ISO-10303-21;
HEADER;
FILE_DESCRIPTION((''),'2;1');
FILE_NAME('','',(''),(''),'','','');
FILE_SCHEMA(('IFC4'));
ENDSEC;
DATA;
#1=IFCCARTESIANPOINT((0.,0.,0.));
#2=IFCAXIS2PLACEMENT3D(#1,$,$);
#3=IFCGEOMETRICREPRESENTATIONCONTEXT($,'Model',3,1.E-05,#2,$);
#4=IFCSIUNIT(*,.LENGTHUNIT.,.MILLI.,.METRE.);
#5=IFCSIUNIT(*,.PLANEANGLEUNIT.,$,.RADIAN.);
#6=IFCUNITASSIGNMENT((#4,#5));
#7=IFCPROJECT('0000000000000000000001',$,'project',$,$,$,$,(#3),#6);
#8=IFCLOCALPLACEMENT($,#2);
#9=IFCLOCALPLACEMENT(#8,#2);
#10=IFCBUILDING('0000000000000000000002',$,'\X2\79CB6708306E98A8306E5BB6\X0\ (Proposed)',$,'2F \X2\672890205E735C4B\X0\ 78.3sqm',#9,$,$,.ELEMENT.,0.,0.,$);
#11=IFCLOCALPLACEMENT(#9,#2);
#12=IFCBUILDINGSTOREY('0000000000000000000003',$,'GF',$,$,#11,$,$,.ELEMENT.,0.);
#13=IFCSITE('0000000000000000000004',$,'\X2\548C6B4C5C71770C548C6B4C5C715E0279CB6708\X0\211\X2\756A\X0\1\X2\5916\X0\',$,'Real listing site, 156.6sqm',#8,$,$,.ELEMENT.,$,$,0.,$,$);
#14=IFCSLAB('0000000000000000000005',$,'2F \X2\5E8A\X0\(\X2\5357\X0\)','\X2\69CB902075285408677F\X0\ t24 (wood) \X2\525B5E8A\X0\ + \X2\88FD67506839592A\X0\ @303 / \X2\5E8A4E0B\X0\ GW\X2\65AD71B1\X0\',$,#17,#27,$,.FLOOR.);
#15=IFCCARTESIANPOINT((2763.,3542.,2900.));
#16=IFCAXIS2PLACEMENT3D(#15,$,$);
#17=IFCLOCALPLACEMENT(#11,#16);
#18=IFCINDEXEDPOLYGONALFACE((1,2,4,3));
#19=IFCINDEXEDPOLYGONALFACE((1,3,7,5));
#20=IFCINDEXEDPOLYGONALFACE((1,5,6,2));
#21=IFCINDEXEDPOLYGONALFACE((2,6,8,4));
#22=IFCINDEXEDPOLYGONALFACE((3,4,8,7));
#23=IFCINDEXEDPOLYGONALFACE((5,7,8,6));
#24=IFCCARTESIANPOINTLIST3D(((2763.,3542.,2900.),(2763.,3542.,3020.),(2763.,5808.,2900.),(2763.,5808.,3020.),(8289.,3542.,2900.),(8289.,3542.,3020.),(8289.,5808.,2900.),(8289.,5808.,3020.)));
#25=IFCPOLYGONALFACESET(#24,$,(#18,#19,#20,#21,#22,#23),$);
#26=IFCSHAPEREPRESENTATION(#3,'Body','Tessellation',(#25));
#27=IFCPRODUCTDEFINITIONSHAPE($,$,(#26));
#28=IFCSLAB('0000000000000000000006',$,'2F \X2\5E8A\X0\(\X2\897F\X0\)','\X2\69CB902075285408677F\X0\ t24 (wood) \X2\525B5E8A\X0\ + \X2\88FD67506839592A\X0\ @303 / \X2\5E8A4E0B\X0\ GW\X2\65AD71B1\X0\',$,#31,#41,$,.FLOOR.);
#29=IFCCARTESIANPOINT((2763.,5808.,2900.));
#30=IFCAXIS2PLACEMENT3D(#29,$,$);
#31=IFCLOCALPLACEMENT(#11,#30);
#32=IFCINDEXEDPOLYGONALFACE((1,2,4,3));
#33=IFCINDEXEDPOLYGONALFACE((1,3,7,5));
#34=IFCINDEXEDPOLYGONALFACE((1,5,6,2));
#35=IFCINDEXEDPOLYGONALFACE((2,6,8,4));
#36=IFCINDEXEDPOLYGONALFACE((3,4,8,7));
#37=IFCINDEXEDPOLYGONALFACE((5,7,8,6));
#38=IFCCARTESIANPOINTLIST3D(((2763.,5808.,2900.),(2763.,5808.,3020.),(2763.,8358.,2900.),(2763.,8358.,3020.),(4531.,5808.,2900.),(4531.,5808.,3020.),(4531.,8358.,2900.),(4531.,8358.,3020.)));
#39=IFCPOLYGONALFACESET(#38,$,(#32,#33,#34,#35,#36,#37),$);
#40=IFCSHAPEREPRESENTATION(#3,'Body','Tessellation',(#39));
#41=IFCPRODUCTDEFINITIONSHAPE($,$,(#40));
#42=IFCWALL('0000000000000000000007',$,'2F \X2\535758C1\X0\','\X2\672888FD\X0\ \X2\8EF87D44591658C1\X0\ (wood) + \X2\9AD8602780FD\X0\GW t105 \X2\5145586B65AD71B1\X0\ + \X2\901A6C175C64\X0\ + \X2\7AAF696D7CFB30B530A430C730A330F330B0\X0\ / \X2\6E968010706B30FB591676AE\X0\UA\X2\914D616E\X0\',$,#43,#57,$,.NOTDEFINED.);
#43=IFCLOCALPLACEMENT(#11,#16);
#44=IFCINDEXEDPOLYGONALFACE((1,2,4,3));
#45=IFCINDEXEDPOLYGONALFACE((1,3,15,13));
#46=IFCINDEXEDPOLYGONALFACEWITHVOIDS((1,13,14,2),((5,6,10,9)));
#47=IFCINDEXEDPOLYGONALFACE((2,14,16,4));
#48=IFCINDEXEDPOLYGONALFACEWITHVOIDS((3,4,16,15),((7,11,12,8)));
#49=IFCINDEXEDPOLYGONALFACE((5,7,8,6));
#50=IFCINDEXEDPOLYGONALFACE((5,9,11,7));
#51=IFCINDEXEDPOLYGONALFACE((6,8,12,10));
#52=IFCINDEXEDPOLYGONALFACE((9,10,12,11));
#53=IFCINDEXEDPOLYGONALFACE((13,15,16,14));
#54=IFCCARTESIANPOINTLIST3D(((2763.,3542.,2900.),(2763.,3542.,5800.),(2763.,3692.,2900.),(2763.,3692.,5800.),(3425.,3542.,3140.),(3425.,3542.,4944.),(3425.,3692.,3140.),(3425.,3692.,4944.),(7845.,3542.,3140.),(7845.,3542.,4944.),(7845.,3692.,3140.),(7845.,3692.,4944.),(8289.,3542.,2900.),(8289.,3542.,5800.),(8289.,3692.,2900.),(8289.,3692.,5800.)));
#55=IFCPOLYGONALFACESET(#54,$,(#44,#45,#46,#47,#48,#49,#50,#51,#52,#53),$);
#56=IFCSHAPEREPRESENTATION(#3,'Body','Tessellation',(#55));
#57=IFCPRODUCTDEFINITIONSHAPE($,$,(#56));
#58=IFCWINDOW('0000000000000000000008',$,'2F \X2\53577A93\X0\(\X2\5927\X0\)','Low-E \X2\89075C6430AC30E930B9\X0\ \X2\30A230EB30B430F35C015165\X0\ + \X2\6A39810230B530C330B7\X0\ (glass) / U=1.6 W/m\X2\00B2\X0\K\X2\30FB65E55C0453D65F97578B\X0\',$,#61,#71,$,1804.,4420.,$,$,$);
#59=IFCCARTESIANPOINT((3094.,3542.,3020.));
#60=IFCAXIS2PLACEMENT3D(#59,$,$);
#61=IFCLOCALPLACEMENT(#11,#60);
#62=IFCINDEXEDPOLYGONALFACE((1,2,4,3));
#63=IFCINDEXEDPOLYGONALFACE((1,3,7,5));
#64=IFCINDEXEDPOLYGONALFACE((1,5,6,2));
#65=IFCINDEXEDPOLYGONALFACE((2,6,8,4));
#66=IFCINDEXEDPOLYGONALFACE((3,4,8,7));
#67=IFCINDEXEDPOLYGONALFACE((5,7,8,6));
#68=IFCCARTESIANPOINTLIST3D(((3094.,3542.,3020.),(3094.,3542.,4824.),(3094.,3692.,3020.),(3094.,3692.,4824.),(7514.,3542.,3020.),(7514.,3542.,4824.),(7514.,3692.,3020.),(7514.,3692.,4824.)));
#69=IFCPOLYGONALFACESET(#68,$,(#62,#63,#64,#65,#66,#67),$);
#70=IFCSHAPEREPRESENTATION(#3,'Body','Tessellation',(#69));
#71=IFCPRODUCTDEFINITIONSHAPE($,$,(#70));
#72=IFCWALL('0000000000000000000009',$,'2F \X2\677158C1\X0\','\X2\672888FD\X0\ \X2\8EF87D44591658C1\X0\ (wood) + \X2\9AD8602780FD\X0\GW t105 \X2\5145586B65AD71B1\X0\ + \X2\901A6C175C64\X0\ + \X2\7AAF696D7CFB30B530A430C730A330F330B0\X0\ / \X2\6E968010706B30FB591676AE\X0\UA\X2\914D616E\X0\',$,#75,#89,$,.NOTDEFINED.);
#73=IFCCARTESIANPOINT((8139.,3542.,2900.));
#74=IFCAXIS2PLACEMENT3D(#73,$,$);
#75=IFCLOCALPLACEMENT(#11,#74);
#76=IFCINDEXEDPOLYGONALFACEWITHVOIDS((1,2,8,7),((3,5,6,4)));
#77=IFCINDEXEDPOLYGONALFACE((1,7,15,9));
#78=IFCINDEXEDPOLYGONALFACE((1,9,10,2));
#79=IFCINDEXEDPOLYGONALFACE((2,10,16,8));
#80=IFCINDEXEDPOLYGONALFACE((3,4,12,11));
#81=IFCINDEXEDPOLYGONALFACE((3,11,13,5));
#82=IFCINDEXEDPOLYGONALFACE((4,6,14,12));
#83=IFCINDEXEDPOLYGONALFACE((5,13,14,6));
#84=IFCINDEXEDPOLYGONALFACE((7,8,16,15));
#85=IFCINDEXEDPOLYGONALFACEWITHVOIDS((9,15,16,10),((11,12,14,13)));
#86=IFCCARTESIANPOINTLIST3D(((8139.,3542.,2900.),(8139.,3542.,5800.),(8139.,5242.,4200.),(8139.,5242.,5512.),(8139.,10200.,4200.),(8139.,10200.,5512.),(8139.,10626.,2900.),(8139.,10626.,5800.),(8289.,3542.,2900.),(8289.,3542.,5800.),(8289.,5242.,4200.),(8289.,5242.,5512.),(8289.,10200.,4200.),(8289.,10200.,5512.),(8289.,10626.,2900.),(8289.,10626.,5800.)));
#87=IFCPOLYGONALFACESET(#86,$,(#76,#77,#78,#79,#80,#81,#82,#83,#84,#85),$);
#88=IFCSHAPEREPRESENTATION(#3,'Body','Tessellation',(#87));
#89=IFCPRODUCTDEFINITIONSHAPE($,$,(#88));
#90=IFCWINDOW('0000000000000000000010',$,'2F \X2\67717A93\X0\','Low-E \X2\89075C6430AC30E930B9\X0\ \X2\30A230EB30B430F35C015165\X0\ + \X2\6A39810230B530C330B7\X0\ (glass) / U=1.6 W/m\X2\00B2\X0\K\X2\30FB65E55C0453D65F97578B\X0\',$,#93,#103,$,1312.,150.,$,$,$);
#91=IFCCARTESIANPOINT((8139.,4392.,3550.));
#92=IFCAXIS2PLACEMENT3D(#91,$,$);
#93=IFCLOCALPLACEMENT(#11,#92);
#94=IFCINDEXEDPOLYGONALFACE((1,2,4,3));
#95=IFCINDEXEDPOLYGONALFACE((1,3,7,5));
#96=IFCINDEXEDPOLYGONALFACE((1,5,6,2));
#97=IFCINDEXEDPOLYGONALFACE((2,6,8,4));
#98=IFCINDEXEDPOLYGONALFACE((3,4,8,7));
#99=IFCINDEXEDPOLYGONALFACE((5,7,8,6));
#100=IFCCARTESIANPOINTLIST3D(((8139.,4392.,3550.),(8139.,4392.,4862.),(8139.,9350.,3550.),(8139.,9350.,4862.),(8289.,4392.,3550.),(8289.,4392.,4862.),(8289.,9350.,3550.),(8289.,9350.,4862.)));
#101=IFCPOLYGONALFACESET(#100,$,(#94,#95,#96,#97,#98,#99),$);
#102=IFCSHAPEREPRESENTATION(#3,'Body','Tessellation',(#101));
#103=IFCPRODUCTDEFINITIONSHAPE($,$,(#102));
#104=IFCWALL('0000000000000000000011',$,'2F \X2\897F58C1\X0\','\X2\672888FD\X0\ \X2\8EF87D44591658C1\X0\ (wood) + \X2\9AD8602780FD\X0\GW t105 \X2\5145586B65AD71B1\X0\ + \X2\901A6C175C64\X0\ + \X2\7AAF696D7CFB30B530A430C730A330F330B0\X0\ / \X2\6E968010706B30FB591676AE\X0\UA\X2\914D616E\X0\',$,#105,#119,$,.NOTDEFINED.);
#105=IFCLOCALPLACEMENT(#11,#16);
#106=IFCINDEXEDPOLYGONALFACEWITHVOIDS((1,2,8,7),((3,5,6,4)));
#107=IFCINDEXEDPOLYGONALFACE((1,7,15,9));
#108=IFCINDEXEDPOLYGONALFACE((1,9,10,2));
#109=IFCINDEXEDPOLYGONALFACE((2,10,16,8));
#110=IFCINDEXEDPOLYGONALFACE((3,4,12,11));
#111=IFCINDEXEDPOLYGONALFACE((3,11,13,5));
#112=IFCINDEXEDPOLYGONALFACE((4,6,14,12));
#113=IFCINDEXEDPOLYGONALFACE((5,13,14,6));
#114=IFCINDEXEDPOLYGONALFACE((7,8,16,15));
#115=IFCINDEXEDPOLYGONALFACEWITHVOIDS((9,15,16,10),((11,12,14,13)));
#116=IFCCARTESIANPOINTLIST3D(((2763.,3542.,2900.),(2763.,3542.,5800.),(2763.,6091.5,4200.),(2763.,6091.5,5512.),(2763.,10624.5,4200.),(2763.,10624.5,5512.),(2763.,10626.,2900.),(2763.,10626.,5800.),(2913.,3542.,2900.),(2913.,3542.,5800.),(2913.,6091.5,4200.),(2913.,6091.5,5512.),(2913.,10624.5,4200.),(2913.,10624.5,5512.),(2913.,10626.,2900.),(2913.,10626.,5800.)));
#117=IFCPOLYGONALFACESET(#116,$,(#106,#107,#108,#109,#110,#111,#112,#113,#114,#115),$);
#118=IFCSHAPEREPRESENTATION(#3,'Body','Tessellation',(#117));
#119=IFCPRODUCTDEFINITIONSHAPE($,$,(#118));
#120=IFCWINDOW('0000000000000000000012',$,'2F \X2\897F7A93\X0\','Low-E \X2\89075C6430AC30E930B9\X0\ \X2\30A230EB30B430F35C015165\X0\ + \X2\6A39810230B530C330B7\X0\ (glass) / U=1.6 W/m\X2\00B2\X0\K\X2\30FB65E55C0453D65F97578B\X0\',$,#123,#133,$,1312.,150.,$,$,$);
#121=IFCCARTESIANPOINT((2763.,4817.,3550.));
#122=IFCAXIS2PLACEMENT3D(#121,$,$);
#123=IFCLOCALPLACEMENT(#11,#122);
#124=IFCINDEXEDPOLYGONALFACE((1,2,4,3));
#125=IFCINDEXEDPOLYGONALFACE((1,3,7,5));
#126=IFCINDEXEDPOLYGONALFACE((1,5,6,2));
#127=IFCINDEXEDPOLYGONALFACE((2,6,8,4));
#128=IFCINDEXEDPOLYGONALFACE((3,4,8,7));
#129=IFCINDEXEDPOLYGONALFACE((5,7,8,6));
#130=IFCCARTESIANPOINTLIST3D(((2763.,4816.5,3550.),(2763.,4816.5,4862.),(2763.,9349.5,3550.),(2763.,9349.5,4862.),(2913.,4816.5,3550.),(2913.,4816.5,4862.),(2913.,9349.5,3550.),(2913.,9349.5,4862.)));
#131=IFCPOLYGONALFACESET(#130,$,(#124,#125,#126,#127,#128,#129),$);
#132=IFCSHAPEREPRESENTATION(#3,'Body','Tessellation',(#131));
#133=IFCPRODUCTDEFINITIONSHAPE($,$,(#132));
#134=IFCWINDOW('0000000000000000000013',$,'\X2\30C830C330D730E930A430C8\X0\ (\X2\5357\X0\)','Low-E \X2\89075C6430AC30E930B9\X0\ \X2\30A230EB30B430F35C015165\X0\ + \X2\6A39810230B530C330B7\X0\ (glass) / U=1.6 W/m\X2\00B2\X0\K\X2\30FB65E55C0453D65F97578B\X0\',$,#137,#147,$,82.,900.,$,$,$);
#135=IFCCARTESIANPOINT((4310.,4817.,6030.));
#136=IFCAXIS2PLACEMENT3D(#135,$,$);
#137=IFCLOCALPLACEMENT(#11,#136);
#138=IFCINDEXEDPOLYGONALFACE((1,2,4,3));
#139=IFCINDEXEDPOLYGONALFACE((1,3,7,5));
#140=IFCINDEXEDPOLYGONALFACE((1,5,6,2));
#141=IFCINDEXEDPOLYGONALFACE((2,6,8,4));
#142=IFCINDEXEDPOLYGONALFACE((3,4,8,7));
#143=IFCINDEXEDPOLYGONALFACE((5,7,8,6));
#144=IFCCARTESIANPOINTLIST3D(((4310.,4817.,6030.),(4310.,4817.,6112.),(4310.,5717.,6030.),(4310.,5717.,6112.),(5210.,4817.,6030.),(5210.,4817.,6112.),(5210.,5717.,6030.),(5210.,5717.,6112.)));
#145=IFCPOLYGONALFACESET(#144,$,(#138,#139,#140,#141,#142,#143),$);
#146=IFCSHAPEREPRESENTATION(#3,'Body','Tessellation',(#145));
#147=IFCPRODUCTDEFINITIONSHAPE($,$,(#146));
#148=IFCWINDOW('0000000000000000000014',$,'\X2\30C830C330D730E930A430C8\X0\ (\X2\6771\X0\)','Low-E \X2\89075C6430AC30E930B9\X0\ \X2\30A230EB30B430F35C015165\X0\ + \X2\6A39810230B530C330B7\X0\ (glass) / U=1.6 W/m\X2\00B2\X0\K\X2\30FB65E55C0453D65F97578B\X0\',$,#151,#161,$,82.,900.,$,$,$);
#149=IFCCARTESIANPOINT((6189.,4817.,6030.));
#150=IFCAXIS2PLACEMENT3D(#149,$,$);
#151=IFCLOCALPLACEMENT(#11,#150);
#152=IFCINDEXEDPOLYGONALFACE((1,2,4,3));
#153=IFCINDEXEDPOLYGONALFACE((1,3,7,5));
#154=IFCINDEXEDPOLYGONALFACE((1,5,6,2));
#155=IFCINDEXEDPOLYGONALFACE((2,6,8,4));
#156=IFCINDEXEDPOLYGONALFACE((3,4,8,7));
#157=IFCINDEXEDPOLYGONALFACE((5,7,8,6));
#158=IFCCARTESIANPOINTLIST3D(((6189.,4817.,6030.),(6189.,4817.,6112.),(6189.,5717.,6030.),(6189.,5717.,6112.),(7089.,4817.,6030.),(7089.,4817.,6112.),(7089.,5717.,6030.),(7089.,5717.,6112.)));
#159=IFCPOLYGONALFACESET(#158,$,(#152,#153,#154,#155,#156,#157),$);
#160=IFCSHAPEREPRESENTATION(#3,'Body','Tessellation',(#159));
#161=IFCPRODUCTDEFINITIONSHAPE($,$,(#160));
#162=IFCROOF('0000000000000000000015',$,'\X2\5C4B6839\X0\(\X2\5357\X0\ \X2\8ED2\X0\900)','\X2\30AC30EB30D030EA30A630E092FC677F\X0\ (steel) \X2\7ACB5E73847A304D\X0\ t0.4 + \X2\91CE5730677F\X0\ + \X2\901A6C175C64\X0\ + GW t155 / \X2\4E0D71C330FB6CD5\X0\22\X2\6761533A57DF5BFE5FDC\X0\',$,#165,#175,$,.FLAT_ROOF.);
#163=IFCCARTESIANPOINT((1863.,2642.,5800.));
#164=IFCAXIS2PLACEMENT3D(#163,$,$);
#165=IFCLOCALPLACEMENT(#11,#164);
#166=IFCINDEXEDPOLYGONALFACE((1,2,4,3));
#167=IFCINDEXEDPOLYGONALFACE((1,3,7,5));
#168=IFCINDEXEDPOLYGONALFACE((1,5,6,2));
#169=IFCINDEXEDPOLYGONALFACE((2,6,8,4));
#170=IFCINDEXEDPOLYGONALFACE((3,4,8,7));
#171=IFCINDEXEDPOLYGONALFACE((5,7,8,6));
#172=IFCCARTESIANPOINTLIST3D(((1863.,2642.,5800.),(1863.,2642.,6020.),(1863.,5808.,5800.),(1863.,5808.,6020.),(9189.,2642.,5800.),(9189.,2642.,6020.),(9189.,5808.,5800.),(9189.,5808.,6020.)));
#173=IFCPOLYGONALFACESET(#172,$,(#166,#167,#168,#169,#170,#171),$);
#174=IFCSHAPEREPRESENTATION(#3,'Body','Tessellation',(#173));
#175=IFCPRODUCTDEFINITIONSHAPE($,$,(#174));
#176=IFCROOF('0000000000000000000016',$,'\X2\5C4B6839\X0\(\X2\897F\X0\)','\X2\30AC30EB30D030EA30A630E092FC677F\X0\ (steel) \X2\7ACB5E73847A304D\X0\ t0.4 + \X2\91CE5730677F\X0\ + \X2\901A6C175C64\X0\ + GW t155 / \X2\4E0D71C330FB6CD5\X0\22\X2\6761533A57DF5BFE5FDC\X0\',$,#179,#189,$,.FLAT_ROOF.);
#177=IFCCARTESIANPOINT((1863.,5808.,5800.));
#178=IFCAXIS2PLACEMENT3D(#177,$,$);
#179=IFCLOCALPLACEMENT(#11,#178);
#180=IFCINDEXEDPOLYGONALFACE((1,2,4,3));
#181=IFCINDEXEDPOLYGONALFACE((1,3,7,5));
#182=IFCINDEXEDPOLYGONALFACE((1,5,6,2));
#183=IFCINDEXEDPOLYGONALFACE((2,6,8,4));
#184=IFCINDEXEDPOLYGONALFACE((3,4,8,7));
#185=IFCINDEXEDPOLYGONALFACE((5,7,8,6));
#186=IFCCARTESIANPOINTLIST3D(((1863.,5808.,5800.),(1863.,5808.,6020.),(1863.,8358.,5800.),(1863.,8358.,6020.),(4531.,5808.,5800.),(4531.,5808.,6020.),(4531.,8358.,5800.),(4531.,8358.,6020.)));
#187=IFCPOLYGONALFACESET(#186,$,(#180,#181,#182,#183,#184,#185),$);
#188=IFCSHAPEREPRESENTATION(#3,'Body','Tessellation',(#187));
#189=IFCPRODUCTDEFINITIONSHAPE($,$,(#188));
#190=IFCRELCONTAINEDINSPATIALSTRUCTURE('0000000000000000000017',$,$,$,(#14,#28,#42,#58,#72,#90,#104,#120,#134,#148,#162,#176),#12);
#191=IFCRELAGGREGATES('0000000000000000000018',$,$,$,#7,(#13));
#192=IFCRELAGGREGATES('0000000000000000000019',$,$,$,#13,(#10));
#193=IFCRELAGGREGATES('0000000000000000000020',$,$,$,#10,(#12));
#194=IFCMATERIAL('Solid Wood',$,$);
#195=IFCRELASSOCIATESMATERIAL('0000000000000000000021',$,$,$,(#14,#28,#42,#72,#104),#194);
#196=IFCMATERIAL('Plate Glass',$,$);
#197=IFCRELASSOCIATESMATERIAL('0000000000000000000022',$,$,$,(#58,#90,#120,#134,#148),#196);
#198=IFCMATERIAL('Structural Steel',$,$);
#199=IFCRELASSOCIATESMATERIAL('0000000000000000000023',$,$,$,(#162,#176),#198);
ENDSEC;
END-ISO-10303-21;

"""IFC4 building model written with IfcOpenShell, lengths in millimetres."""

from ifc_helpers import new_model, si_unit, frame, frame_2d, origin, place, context, project, spatial, rectangle, extrude, material, element, fill, save


model = new_model("IFC4")

# Units and contexts
model_context = context("Model", 3, precision=1e-05, world=origin())
ifc_project = project(units=[si_unit("LENGTHUNIT", "METRE", prefix="MILLI"), si_unit("PLANEANGLEUNIT", "RADIAN")], contexts=[model_context])

# Site, building, storey
site_placement = place(None, origin())
site = spatial("IfcSite", under=ifc_project, at=site_placement, Name="和歌山県和歌山市秋月211番1外", ObjectType="Real listing site, 156.6sqm", CompositionType="ELEMENT", RefElevation=0.0)
building_placement = place(site_placement, origin())
building = spatial("IfcBuilding", under=site, at=building_placement, Name="秋月の風の家 (Proposed)", ObjectType="2F 木造平屋 78.3sqm", CompositionType="ELEMENT", ElevationOfRefHeight=0.0, ElevationOfTerrain=0.0)
storey_placement = place(building_placement, origin())
storey = spatial("IfcBuildingStorey", under=building, at=storey_placement, Name="GF", CompositionType="ELEMENT", Elevation=0.0)

# Slabs
ifc_material_1 = material(Name="Solid Wood")
slab_1_placement = place(storey_placement, frame((2763.0, 3542.0, 2900.0)))
element("IfcSlab", 1, at=slab_1_placement, inside=storey, material=ifc_material_1, Name="2F 床(南)", Description="構造用合板 t24 (wood) 剛床 + 製材根太 @303 / 床下 GW断熱", PredefinedType="FLOOR", context=model_context, shape_type="SweptSolid", body=[
    extrude(rectangle(XDim=5526.0, YDim=2266.0, at=frame_2d((2763.0, 1133.0))), frame((2763.0, 3542.0, 2900.0)), (0.0, 0.0, 1.0), 120.0),
])
slab_2_placement = place(storey_placement, frame((2763.0, 5808.0, 2900.0)))
element("IfcSlab", 2, at=slab_2_placement, inside=storey, material=ifc_material_1, Name="2F 床(西)", Description="構造用合板 t24 (wood) 剛床 + 製材根太 @303 / 床下 GW断熱", PredefinedType="FLOOR", context=model_context, shape_type="SweptSolid", body=[
    extrude(rectangle(XDim=1768.0, YDim=2550.0, at=frame_2d((884.0, 1275.0))), frame((2763.0, 5808.0, 2900.0)), (0.0, 0.0, 1.0), 120.0),
])

# Walls, openings, windows
wall_1_placement = place(storey_placement, frame((2763.0, 3542.0, 2900.0)))
wall_1 = element("IfcWall", 3, at=wall_1_placement, inside=storey, material=ifc_material_1, Name="2F 南壁", Description="木製 軸組外壁 (wood) + 高性能GW t105 充填断熱 + 通気層 + 窯業系サイディング / 準耐火・外皮UA配慮", PredefinedType="NOTDEFINED", context=model_context, shape_type="SweptSolid", body=[
    extrude(rectangle(XDim=5526.0, YDim=150.0, at=frame_2d((2763.0, 75.0))), frame((2763.0, 3542.0, 2900.0)), (0.0, 0.0, 1.0), 2900.0),
])
opening_1_placement = place(storey_placement, frame((3094.0, 3542.0, 3020.0)))
opening_1 = element("IfcOpeningElement", 4, at=opening_1_placement, cuts=wall_1, PredefinedType="NOTDEFINED", context=model_context, shape_type="SweptSolid", body=[
    extrude(rectangle(XDim=4420.0, YDim=150.0, at=frame_2d((2210.0, 75.0))), frame((3094.0, 3542.0, 3020.0)), (0.0, 0.0, 1.0), 1804.0),
])
ifc_material_2 = material(Name="Plate Glass")
window_1_placement = place(storey_placement, frame((3094.0, 3542.0, 3020.0)))
window_1 = element("IfcWindow", 5, at=window_1_placement, inside=storey, material=ifc_material_2, Name="2F 南窓(大)", Description="Low-E 複層ガラス アルゴン封入 + 樹脂サッシ (glass) / U=1.6 W/m²K・日射取得型", OverallHeight=1804.0, OverallWidth=4420.0, context=model_context, shape_type="SweptSolid", body=[
    extrude(rectangle(XDim=4420.0, YDim=150.0, at=frame_2d((2210.0, 75.0))), frame((3094.0, 3542.0, 3020.0)), (0.0, 0.0, 1.0), 1804.0),
])
fill(opening_1, window_1)
wall_2_placement = place(storey_placement, frame((8139.0, 3542.0, 2900.0)))
wall_2 = element("IfcWall", 6, at=wall_2_placement, inside=storey, material=ifc_material_1, Name="2F 東壁", Description="木製 軸組外壁 (wood) + 高性能GW t105 充填断熱 + 通気層 + 窯業系サイディング / 準耐火・外皮UA配慮", PredefinedType="NOTDEFINED", context=model_context, shape_type="SweptSolid", body=[
    extrude(rectangle(XDim=150.0, YDim=7084.0, at=frame_2d((75.0, 3542.0))), frame((8139.0, 3542.0, 2900.0)), (0.0, 0.0, 1.0), 2900.0),
])
opening_2_placement = place(storey_placement, frame((8139.0, 4392.0, 3550.0)))
opening_2 = element("IfcOpeningElement", 7, at=opening_2_placement, cuts=wall_2, PredefinedType="NOTDEFINED", context=model_context, shape_type="SweptSolid", body=[
    extrude(rectangle(XDim=150.0, YDim=4958.0, at=frame_2d((75.0, 2479.0))), frame((8139.0, 4392.0, 3550.0)), (0.0, 0.0, 1.0), 1312.0),
])
window_2_placement = place(storey_placement, frame((8139.0, 4392.0, 3550.0)))
window_2 = element("IfcWindow", 8, at=window_2_placement, inside=storey, material=ifc_material_2, Name="2F 東窓", Description="Low-E 複層ガラス アルゴン封入 + 樹脂サッシ (glass) / U=1.6 W/m²K・日射取得型", OverallHeight=1312.0, OverallWidth=150.0, context=model_context, shape_type="SweptSolid", body=[
    extrude(rectangle(XDim=150.0, YDim=4958.0, at=frame_2d((75.0, 2479.0))), frame((8139.0, 4392.0, 3550.0)), (0.0, 0.0, 1.0), 1312.0),
])
fill(opening_2, window_2)
wall_3_placement = place(storey_placement, frame((2763.0, 3542.0, 2900.0)))
wall_3 = element("IfcWall", 9, at=wall_3_placement, inside=storey, material=ifc_material_1, Name="2F 西壁", Description="木製 軸組外壁 (wood) + 高性能GW t105 充填断熱 + 通気層 + 窯業系サイディング / 準耐火・外皮UA配慮", PredefinedType="NOTDEFINED", context=model_context, shape_type="SweptSolid", body=[
    extrude(rectangle(XDim=150.0, YDim=7084.0, at=frame_2d((75.0, 3542.0))), frame((2763.0, 3542.0, 2900.0)), (0.0, 0.0, 1.0), 2900.0),
])
opening_3_placement = place(storey_placement, frame((2763.0, 4817.0, 3550.0)))
opening_3 = element("IfcOpeningElement", 10, at=opening_3_placement, cuts=wall_3, PredefinedType="NOTDEFINED", context=model_context, shape_type="SweptSolid", body=[
    extrude(rectangle(XDim=150.0, YDim=4533.0, at=frame_2d((75.0, 2266.0))), frame((2763.0, 4817.0, 3550.0)), (0.0, 0.0, 1.0), 1312.0),
])
window_3_placement = place(storey_placement, frame((2763.0, 4817.0, 3550.0)))
window_3 = element("IfcWindow", 11, at=window_3_placement, inside=storey, material=ifc_material_2, Name="2F 西窓", Description="Low-E 複層ガラス アルゴン封入 + 樹脂サッシ (glass) / U=1.6 W/m²K・日射取得型", OverallHeight=1312.0, OverallWidth=150.0, context=model_context, shape_type="SweptSolid", body=[
    extrude(rectangle(XDim=150.0, YDim=4533.0, at=frame_2d((75.0, 2266.0))), frame((2763.0, 4817.0, 3550.0)), (0.0, 0.0, 1.0), 1312.0),
])
fill(opening_3, window_3)

# Windows
window_4_placement = place(storey_placement, frame((4310.0, 4817.0, 6030.0)))
element("IfcWindow", 12, at=window_4_placement, inside=storey, material=ifc_material_2, Name="トップライト (南)", Description="Low-E 複層ガラス アルゴン封入 + 樹脂サッシ (glass) / U=1.6 W/m²K・日射取得型", OverallHeight=82.0, OverallWidth=900.0, context=model_context, shape_type="SweptSolid", body=[
    extrude(rectangle(XDim=900.0, YDim=900.0, at=frame_2d((450.0, 450.0))), frame((4310.0, 4817.0, 6030.0)), (0.0, 0.0, 1.0), 82.0),
])
window_5_placement = place(storey_placement, frame((6189.0, 4817.0, 6030.0)))
element("IfcWindow", 13, at=window_5_placement, inside=storey, material=ifc_material_2, Name="トップライト (東)", Description="Low-E 複層ガラス アルゴン封入 + 樹脂サッシ (glass) / U=1.6 W/m²K・日射取得型", OverallHeight=82.0, OverallWidth=900.0, context=model_context, shape_type="SweptSolid", body=[
    extrude(rectangle(XDim=900.0, YDim=900.0, at=frame_2d((450.0, 450.0))), frame((6189.0, 4817.0, 6030.0)), (0.0, 0.0, 1.0), 82.0),
])

# Roofs
ifc_material_3 = material(Name="Structural Steel")
roof_1_placement = place(storey_placement, frame((1863.0, 2642.0, 5800.0)))
element("IfcRoof", 14, at=roof_1_placement, inside=storey, material=ifc_material_3, Name="屋根(南 軒900)", Description="ガルバリウム鋼板 (steel) 立平葺き t0.4 + 野地板 + 通気層 + GW t155 / 不燃・法22条区域対応", PredefinedType="FLAT_ROOF", context=model_context, shape_type="SweptSolid", body=[
    extrude(rectangle(XDim=7326.0, YDim=3166.0, at=frame_2d((3663.0, 1583.0))), frame((1863.0, 2642.0, 5800.0)), (0.0, 0.0, 1.0), 220.0),
])
roof_2_placement = place(storey_placement, frame((1863.0, 5808.0, 5800.0)))
element("IfcRoof", 15, at=roof_2_placement, inside=storey, material=ifc_material_3, Name="屋根(西)", Description="ガルバリウム鋼板 (steel) 立平葺き t0.4 + 野地板 + 通気層 + GW t155 / 不燃・法22条区域対応", PredefinedType="FLAT_ROOF", context=model_context, shape_type="SweptSolid", body=[
    extrude(rectangle(XDim=2668.0, YDim=2550.0, at=frame_2d((1334.0, 1275.0))), frame((1863.0, 5808.0, 5800.0)), (0.0, 0.0, 1.0), 220.0),
])

save(model, "model.ifc")
